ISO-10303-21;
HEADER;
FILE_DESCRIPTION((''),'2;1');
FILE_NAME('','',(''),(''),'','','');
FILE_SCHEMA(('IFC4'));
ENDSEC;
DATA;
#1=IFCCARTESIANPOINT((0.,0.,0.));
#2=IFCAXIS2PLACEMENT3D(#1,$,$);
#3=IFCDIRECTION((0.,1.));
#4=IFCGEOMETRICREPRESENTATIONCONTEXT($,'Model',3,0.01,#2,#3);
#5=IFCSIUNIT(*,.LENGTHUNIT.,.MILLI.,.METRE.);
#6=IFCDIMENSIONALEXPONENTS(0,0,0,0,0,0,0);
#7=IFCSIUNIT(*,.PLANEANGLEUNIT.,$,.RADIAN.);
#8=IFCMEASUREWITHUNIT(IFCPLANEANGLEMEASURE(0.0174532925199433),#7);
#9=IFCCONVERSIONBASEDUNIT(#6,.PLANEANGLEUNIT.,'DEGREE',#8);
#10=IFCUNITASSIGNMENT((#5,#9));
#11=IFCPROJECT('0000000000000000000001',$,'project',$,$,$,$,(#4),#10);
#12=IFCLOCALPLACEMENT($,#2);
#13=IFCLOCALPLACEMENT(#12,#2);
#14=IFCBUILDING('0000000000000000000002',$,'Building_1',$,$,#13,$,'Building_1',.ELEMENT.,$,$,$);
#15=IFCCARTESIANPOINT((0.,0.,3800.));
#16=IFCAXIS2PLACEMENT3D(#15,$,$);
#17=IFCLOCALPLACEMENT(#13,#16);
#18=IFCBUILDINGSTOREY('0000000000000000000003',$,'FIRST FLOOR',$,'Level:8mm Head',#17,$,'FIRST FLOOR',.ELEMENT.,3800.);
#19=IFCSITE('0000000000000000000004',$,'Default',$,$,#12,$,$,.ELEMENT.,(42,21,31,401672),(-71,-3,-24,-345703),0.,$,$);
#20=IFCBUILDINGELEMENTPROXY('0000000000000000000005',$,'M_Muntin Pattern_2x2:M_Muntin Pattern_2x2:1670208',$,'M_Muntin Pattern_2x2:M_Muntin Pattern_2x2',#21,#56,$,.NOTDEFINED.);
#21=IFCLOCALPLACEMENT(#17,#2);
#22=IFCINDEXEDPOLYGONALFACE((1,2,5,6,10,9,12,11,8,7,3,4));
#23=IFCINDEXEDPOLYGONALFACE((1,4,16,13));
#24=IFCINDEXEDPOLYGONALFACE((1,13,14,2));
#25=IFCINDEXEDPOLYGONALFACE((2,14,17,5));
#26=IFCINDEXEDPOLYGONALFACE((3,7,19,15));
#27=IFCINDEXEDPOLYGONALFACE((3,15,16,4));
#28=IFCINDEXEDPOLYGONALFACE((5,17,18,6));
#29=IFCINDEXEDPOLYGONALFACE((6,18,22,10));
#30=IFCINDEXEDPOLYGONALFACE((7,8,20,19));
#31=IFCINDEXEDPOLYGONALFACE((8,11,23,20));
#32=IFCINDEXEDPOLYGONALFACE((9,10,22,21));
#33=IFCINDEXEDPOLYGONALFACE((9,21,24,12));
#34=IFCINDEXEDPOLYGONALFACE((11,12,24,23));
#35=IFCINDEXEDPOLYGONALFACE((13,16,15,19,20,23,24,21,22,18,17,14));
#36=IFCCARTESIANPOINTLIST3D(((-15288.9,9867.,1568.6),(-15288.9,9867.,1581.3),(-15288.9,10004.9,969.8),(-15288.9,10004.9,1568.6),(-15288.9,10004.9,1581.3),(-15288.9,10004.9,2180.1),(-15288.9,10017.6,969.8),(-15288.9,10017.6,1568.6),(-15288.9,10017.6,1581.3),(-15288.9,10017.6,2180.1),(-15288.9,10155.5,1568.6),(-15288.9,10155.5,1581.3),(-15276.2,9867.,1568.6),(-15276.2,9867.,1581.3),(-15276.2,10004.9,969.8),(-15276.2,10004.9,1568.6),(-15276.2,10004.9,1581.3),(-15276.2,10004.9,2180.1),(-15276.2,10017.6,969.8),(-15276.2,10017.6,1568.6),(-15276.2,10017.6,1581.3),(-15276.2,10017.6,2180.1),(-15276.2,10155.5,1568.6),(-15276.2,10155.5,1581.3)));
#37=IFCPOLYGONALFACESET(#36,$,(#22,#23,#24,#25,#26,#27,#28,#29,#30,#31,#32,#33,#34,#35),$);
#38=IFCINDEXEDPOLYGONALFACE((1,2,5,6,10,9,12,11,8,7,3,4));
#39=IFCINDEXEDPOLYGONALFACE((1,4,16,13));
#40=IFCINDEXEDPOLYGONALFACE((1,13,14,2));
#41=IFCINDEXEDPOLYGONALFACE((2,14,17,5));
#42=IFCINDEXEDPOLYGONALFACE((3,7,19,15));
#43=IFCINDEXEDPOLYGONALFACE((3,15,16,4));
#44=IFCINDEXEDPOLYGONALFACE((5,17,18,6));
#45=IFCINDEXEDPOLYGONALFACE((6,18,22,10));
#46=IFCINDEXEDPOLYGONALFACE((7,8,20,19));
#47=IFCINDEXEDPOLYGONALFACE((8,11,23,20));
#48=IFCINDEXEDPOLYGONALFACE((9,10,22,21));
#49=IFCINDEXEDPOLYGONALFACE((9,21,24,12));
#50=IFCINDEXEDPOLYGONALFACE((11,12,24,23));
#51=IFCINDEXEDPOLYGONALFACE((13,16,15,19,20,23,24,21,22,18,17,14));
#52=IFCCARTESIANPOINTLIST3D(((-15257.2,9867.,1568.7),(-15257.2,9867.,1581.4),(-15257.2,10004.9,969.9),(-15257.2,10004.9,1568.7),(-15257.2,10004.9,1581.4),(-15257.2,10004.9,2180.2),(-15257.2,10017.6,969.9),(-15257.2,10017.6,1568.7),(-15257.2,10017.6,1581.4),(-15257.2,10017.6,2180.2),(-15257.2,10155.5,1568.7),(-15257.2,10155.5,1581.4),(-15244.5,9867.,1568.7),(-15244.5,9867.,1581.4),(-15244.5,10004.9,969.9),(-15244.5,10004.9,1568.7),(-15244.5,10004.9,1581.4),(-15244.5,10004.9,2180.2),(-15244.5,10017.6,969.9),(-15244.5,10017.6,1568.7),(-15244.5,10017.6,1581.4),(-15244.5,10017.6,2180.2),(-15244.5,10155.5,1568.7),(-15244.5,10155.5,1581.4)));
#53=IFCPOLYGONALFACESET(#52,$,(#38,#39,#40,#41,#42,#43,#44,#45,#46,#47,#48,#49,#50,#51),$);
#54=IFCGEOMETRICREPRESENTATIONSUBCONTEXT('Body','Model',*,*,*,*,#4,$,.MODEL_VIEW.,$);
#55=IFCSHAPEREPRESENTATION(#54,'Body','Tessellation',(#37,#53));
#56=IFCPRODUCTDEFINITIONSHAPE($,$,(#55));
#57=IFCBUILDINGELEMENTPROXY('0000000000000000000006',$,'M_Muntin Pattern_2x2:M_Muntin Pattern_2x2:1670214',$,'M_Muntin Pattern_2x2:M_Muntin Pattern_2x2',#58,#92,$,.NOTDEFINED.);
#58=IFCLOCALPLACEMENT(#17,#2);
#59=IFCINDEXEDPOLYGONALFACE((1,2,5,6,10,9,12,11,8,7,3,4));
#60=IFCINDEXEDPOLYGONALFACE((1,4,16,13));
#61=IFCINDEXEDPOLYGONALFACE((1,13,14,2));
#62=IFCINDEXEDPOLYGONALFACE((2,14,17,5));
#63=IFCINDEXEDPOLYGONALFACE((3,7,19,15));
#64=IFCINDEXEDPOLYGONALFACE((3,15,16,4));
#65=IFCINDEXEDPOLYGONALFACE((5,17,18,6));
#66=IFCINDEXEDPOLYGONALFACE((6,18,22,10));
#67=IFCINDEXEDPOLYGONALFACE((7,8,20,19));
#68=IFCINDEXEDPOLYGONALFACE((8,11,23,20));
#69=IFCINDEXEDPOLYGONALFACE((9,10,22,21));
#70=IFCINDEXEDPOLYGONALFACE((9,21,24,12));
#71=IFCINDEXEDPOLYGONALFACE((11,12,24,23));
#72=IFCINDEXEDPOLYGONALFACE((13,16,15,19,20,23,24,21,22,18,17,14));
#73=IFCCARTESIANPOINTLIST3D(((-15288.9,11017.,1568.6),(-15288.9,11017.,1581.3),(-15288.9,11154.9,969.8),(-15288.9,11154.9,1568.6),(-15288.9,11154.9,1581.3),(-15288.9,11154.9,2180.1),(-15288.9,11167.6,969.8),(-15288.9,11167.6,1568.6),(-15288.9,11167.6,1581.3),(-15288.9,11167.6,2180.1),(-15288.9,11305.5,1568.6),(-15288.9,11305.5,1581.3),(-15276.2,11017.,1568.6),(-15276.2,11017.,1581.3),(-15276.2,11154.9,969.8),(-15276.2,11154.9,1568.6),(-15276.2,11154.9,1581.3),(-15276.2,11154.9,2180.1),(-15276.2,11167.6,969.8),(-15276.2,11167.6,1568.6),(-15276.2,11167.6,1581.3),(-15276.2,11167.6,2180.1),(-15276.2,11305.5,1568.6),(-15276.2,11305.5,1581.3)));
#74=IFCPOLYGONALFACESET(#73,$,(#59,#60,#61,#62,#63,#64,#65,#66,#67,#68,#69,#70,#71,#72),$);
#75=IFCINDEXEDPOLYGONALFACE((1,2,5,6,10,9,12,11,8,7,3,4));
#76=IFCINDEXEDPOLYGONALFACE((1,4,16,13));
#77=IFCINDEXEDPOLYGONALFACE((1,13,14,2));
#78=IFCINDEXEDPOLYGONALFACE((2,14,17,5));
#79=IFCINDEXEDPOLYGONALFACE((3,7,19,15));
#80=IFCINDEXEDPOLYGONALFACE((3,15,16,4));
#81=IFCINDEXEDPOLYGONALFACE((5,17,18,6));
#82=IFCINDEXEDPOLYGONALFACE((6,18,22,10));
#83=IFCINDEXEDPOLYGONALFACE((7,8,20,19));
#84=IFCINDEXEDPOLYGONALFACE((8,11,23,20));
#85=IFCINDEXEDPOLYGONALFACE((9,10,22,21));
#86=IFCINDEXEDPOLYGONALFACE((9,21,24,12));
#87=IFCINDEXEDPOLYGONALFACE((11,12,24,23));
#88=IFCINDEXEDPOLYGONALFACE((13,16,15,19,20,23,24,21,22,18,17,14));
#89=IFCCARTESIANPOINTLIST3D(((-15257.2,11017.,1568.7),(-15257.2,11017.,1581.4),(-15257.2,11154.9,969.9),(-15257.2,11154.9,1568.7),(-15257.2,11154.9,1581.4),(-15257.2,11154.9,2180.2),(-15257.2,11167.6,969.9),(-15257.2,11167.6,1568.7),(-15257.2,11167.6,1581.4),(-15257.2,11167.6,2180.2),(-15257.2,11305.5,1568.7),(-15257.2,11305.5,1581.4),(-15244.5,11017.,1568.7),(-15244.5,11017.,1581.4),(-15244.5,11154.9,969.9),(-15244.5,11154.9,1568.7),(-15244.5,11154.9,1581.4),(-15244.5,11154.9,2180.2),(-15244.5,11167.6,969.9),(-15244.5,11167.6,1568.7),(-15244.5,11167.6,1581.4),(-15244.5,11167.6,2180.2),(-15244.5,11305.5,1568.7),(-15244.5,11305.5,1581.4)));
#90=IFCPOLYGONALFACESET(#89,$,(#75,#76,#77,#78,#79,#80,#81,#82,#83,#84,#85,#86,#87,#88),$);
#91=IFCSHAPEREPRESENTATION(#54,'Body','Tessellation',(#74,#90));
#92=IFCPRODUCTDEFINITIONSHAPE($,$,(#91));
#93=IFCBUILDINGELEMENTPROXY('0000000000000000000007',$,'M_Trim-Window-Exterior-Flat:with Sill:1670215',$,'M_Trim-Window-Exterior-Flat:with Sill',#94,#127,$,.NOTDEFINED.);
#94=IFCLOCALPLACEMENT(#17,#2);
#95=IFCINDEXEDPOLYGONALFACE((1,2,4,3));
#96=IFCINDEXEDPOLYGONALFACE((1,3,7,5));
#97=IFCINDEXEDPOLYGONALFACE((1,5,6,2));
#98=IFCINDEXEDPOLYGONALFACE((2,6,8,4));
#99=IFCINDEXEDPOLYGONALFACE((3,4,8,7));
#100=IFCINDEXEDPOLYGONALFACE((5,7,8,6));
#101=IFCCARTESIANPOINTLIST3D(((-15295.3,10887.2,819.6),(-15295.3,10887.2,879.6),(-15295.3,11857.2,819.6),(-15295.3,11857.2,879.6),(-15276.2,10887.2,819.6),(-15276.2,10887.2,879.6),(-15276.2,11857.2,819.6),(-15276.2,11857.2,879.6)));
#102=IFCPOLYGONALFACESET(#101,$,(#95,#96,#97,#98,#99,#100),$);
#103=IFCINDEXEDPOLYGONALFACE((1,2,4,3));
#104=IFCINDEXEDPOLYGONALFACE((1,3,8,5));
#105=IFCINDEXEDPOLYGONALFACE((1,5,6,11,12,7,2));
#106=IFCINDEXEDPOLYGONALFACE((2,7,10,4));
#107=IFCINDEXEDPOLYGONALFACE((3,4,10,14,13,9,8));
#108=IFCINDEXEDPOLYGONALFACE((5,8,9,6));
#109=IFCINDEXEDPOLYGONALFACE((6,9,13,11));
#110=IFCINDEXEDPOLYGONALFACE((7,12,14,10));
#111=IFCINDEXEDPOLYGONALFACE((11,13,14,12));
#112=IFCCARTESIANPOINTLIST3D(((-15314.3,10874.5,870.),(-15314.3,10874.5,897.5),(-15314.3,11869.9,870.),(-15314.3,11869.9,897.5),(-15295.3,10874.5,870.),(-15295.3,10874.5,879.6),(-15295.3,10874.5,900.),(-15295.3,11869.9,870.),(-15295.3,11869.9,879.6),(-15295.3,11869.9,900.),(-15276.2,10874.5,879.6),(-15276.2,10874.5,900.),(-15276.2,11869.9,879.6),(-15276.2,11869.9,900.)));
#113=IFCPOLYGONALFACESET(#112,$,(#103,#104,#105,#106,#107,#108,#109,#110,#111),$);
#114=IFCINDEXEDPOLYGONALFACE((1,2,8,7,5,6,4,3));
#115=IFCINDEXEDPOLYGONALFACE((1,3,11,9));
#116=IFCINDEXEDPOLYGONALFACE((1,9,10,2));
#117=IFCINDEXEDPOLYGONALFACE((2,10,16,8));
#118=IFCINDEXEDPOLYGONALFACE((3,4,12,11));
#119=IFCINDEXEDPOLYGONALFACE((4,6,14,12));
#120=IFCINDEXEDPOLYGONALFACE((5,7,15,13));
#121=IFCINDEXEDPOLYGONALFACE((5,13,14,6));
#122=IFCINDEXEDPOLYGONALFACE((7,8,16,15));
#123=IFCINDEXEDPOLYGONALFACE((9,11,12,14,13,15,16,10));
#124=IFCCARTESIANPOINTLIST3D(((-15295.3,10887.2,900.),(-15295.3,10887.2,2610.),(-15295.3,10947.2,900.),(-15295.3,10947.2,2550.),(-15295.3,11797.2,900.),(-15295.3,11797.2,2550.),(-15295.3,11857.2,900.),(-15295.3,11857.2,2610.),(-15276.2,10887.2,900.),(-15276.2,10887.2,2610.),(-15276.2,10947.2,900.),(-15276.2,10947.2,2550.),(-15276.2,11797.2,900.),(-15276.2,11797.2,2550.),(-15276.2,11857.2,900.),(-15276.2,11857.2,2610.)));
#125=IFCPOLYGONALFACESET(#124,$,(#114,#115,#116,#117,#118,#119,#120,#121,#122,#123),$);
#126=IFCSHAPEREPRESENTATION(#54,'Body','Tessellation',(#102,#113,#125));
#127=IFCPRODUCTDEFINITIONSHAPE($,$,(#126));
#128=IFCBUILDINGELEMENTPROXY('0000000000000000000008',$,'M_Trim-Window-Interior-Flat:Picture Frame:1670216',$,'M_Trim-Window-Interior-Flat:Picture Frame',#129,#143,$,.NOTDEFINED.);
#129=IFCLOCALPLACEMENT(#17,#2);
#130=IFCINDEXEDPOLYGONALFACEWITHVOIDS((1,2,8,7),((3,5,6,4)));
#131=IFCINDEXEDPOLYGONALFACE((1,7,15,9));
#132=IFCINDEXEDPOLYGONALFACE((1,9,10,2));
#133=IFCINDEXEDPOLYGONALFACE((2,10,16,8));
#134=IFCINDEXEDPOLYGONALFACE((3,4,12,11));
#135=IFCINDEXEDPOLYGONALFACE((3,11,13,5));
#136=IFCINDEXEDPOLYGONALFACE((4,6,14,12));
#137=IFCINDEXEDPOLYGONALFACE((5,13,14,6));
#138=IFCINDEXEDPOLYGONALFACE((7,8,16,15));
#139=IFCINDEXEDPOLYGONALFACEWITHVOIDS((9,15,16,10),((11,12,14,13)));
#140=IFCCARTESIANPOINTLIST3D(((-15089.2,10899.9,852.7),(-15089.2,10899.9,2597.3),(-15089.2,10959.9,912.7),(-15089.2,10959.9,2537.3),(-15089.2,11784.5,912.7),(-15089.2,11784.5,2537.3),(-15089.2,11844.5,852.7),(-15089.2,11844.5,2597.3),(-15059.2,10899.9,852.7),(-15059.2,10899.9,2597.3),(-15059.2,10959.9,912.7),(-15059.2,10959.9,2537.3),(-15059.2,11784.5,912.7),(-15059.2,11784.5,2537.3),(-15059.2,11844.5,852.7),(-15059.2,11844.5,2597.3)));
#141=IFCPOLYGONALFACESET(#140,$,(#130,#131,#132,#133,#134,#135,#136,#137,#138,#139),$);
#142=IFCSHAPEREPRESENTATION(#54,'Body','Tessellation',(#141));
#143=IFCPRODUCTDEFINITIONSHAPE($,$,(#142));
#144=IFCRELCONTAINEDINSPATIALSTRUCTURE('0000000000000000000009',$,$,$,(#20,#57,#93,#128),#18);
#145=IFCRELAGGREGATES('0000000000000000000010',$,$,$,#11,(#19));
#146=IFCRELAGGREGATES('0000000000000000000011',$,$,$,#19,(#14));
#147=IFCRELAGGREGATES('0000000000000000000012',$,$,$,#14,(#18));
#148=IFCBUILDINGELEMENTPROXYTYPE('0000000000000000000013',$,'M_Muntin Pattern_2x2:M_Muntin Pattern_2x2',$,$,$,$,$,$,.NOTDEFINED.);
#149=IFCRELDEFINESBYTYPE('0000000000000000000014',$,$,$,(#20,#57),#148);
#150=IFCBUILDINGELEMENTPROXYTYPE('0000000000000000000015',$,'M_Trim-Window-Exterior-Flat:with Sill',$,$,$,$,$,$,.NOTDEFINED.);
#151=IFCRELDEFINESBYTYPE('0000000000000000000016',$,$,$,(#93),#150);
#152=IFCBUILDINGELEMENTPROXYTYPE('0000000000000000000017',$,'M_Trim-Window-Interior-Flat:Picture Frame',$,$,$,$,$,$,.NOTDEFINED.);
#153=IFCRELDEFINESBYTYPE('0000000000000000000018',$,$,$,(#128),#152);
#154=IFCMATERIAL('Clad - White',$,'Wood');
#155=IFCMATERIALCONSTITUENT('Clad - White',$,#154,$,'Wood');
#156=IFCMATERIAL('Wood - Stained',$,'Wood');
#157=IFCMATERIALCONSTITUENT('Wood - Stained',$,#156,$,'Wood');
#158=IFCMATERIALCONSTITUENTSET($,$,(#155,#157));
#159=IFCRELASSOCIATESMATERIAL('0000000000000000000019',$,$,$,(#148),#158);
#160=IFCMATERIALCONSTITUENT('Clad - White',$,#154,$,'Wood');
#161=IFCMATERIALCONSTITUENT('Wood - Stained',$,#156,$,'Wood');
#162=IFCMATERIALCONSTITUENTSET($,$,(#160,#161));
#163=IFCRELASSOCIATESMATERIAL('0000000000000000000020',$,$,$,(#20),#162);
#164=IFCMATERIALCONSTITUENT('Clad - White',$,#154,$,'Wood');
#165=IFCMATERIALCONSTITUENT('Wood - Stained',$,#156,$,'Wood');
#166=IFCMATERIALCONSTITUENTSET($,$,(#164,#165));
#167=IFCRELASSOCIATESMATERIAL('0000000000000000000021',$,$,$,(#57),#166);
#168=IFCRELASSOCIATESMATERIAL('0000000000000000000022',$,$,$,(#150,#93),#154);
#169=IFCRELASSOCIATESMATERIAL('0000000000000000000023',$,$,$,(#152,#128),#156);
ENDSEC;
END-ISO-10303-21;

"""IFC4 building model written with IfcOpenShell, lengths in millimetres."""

from ifc_helpers import new_model, entity, si_unit, converted_unit, direction, frame, origin, place, context, subcontext, project, spatial, indexed_curve, outline, extrude, source, transform, mapped, material, constituent, constituent_set, type_object, type_shapes, element, save


model = new_model("IFC4")

# Units and contexts
model_context = context("Model", 3, precision=0.01, world=origin(), true_north=direction((0.0, 1.0)))
body_context = subcontext(model_context, "Body", "Model", "MODEL_VIEW")
ifc_project = project(units=[si_unit("LENGTHUNIT", "METRE", prefix="MILLI"), converted_unit("PLANEANGLEUNIT", "DEGREE", entity("IfcPlaneAngleMeasure", 0.0174532925199433), si_unit("PLANEANGLEUNIT", "RADIAN"), dimensions=[0, 0, 0, 0, 0, 0, 0])], contexts=[model_context])

# Site, building, storey
site_placement = place(None, origin())
site = spatial("IfcSite", under=ifc_project, at=site_placement, Name="Default", CompositionType="ELEMENT", RefLatitude=(42, 21, 31, 401672), RefLongitude=(-71, -3, -24, -345703), RefElevation=0.0)
building_placement = place(site_placement, origin())
building = spatial("IfcBuilding", under=site, at=building_placement, Name="Building_1", LongName="Building_1", CompositionType="ELEMENT")
storey_placement = place(building_placement, frame((0.0, 0.0, 3800.0)))
storey = spatial("IfcBuildingStorey", under=building, at=storey_placement, Name="FIRST FLOOR", ObjectType="Level:8mm Head", LongName="FIRST FLOOR", CompositionType="ELEMENT", Elevation=3800.0)

# Shared definitions
ifc_material_1 = material(Name="Wood - Stained", Category="Wood")

# Building element proxies
ifc_material_2 = material(Name="Clad - White", Category="Wood")
ifc_constituent_1 = constituent(ifc_material_2, Name="Clad - White", Category="Wood")
ifc_constituent_2 = constituent(ifc_material_1, Name="Wood - Stained", Category="Wood")
ifc_constituent_set_1 = constituent_set(constituents=[ifc_constituent_1, ifc_constituent_2])
ifc_constituent_3 = constituent(ifc_material_2, Name="Clad - White", Category="Wood")
ifc_constituent_4 = constituent(ifc_material_1, Name="Wood - Stained", Category="Wood")
ifc_constituent_set_2 = constituent_set(constituents=[ifc_constituent_3, ifc_constituent_4])
building_element_proxy_type_1 = type_object("IfcBuildingElementProxyType", Name="M_Muntin Pattern_2x2:M_Muntin Pattern_2x2", PredefinedType="NOTDEFINED", material=ifc_constituent_set_2)
shared_shape_1 = source(origin(), body_context, "Body", "SweptSolid", [
    extrude(outline(indexed_curve([(6.4, -6.4), (605.1, -6.4), (605.1, 6.3), (6.4, 6.3), (6.4, 144.2), (-6.3, 144.2), (-6.3, 6.3), (-605.2, 6.3), (-605.2, -6.4), (-6.3, -6.4), (-6.3, -144.2), (6.4, -144.2), (6.4, -6.4)], self_intersect=False)), frame((0.0, 9.5, 605.1), z_axis=(0.0, 1.0, 0.0), x_axis=(0.0, 0.0, 1.0)), (0.0, 0.0, 1.0), 12.7),
    extrude(outline(indexed_curve([(6.4, -6.4), (605.2, -6.4), (605.2, 6.3), (6.4, 6.3), (6.4, 144.2), (-6.3, 144.2), (-6.3, 6.3), (-605.2, 6.3), (-605.2, -6.4), (-6.3, -6.4), (-6.3, -144.2), (6.4, -144.2), (6.4, -6.4)], self_intersect=False)), frame((0.0, -22.2, 605.2), z_axis=(0.0, 1.0, 0.0), x_axis=(0.0, 0.0, 1.0)), (0.0, 0.0, 1.0), 12.7),
])
type_shapes(building_element_proxy_type_1, [shared_shape_1])
proxy_1_placement = place(storey_placement, frame((-15266.7, 10011.3, 969.9), z_axis=(0.0, 0.0, 1.0), x_axis=(0.0, 1.0, 0.0)))
element("IfcBuildingElementProxy", 1, at=proxy_1_placement, inside=storey, type_object=building_element_proxy_type_1, material=ifc_constituent_set_1, Name="M_Muntin Pattern_2x2:M_Muntin Pattern_2x2:1670208", ObjectType="M_Muntin Pattern_2x2:M_Muntin Pattern_2x2", PredefinedType="NOTDEFINED", context=body_context, shape_type="MappedRepresentation", body=[
    mapped(shared_shape_1, transform((0.0, 0.0, 0.0), scale=1.0)),
])
ifc_constituent_5 = constituent(ifc_material_2, Name="Clad - White", Category="Wood")
ifc_constituent_6 = constituent(ifc_material_1, Name="Wood - Stained", Category="Wood")
ifc_constituent_set_3 = constituent_set(constituents=[ifc_constituent_5, ifc_constituent_6])
proxy_2_placement = place(storey_placement, frame((-15266.7, 11161.3, 969.9), z_axis=(0.0, 0.0, 1.0), x_axis=(0.0, 1.0, 0.0)))
element("IfcBuildingElementProxy", 2, at=proxy_2_placement, inside=storey, type_object=building_element_proxy_type_1, material=ifc_constituent_set_3, Name="M_Muntin Pattern_2x2:M_Muntin Pattern_2x2:1670214", ObjectType="M_Muntin Pattern_2x2:M_Muntin Pattern_2x2", PredefinedType="NOTDEFINED", context=body_context, shape_type="MappedRepresentation", body=[
    mapped(shared_shape_1, transform((0.0, 0.0, 0.0), scale=1.0)),
])
building_element_proxy_type_2 = type_object("IfcBuildingElementProxyType", Name="M_Trim-Window-Exterior-Flat:with Sill", PredefinedType="NOTDEFINED", material=ifc_material_2)
shared_shape_2 = source(origin(), body_context, "Body", "SweptSolid", [
    extrude(outline(indexed_curve([(-30.0, -485.0), (30.0, -485.0), (30.0, 485.0), (-30.0, 485.0), (-30.0, -485.0)], self_intersect=False)), frame((0.0, 1700.4, 0.0), z_axis=(0.0, 0.0, 1.0), x_axis=(0.0, 1.0, 0.0)), (0.0, 0.0, 1.0), 19.1),
    extrude(outline(indexed_curve([(-15.2, -19.0), (12.3, -19.0), (14.8, 0.0), (14.8, 19.0), (-5.7, 19.0), (-5.7, 0.0), (-15.2, 0.0), (-15.2, -19.0)], self_intersect=False)), frame((-497.7, 1664.8, 19.0), z_axis=(1.0, 0.0, 0.0), x_axis=(0.0, -1.0, 0.0)), (0.0, 0.0, 1.0), 995.4),
    extrude(outline(indexed_curve([(-485.0, -870.0), (485.0, -870.0), (485.0, 840.0), (425.0, 840.0), (425.0, -810.0), (-425.0, -810.0), (-425.0, 840.0), (-485.0, 840.0), (-485.0, -870.0)], self_intersect=False)), frame((0.0, 810.0, 0.0)), (0.0, 0.0, 1.0), 19.1),
])
type_shapes(building_element_proxy_type_2, [shared_shape_2])
proxy_3_placement = place(storey_placement, frame((-15276.2, 11372.2, 2550.0), z_axis=(-1.0, 0.0, 0.0), x_axis=(0.0, 1.0, 0.0)))
element("IfcBuildingElementProxy", 3, at=proxy_3_placement, inside=storey, type_object=building_element_proxy_type_2, material=ifc_material_2, Name="M_Trim-Window-Exterior-Flat:with Sill:1670215", ObjectType="M_Trim-Window-Exterior-Flat:with Sill", PredefinedType="NOTDEFINED", context=body_context, shape_type="MappedRepresentation", body=[
    mapped(shared_shape_2, transform((0.0, 0.0, 0.0), scale=1.0)),
])
building_element_proxy_type_3 = type_object("IfcBuildingElementProxyType", Name="M_Trim-Window-Interior-Flat:Picture Frame", PredefinedType="NOTDEFINED", material=ifc_material_1)
shared_shape_3 = source(origin(), body_context, "Body", "SweptSolid", [
    extrude(outline(indexed_curve([(-872.3, -472.3), (872.3, -472.3), (872.3, 472.3), (-872.3, 472.3), (-872.3, -472.3)], self_intersect=False), holes=[indexed_curve([(-812.3, -412.3), (-812.3, 412.3), (812.3, 412.3), (812.3, -412.3), (-812.3, -412.3)], self_intersect=False)]), frame((0.0, 825.0, 0.0), z_axis=(0.0, 0.0, 1.0), x_axis=(0.0, 1.0, 0.0)), (0.0, 0.0, 1.0), 30.0),
])
type_shapes(building_element_proxy_type_3, [shared_shape_3])
proxy_4_placement = place(storey_placement, frame((-15089.2, 11372.2, 2550.0), z_axis=(1.0, 0.0, 0.0), x_axis=(0.0, -1.0, 0.0)))
element("IfcBuildingElementProxy", 4, at=proxy_4_placement, inside=storey, type_object=building_element_proxy_type_3, material=ifc_material_1, Name="M_Trim-Window-Interior-Flat:Picture Frame:1670216", ObjectType="M_Trim-Window-Interior-Flat:Picture Frame", PredefinedType="NOTDEFINED", context=body_context, shape_type="MappedRepresentation", body=[
    mapped(shared_shape_3, transform((0.0, 0.0, 0.0), scale=1.0)),
])

save(model, "model.ifc")
